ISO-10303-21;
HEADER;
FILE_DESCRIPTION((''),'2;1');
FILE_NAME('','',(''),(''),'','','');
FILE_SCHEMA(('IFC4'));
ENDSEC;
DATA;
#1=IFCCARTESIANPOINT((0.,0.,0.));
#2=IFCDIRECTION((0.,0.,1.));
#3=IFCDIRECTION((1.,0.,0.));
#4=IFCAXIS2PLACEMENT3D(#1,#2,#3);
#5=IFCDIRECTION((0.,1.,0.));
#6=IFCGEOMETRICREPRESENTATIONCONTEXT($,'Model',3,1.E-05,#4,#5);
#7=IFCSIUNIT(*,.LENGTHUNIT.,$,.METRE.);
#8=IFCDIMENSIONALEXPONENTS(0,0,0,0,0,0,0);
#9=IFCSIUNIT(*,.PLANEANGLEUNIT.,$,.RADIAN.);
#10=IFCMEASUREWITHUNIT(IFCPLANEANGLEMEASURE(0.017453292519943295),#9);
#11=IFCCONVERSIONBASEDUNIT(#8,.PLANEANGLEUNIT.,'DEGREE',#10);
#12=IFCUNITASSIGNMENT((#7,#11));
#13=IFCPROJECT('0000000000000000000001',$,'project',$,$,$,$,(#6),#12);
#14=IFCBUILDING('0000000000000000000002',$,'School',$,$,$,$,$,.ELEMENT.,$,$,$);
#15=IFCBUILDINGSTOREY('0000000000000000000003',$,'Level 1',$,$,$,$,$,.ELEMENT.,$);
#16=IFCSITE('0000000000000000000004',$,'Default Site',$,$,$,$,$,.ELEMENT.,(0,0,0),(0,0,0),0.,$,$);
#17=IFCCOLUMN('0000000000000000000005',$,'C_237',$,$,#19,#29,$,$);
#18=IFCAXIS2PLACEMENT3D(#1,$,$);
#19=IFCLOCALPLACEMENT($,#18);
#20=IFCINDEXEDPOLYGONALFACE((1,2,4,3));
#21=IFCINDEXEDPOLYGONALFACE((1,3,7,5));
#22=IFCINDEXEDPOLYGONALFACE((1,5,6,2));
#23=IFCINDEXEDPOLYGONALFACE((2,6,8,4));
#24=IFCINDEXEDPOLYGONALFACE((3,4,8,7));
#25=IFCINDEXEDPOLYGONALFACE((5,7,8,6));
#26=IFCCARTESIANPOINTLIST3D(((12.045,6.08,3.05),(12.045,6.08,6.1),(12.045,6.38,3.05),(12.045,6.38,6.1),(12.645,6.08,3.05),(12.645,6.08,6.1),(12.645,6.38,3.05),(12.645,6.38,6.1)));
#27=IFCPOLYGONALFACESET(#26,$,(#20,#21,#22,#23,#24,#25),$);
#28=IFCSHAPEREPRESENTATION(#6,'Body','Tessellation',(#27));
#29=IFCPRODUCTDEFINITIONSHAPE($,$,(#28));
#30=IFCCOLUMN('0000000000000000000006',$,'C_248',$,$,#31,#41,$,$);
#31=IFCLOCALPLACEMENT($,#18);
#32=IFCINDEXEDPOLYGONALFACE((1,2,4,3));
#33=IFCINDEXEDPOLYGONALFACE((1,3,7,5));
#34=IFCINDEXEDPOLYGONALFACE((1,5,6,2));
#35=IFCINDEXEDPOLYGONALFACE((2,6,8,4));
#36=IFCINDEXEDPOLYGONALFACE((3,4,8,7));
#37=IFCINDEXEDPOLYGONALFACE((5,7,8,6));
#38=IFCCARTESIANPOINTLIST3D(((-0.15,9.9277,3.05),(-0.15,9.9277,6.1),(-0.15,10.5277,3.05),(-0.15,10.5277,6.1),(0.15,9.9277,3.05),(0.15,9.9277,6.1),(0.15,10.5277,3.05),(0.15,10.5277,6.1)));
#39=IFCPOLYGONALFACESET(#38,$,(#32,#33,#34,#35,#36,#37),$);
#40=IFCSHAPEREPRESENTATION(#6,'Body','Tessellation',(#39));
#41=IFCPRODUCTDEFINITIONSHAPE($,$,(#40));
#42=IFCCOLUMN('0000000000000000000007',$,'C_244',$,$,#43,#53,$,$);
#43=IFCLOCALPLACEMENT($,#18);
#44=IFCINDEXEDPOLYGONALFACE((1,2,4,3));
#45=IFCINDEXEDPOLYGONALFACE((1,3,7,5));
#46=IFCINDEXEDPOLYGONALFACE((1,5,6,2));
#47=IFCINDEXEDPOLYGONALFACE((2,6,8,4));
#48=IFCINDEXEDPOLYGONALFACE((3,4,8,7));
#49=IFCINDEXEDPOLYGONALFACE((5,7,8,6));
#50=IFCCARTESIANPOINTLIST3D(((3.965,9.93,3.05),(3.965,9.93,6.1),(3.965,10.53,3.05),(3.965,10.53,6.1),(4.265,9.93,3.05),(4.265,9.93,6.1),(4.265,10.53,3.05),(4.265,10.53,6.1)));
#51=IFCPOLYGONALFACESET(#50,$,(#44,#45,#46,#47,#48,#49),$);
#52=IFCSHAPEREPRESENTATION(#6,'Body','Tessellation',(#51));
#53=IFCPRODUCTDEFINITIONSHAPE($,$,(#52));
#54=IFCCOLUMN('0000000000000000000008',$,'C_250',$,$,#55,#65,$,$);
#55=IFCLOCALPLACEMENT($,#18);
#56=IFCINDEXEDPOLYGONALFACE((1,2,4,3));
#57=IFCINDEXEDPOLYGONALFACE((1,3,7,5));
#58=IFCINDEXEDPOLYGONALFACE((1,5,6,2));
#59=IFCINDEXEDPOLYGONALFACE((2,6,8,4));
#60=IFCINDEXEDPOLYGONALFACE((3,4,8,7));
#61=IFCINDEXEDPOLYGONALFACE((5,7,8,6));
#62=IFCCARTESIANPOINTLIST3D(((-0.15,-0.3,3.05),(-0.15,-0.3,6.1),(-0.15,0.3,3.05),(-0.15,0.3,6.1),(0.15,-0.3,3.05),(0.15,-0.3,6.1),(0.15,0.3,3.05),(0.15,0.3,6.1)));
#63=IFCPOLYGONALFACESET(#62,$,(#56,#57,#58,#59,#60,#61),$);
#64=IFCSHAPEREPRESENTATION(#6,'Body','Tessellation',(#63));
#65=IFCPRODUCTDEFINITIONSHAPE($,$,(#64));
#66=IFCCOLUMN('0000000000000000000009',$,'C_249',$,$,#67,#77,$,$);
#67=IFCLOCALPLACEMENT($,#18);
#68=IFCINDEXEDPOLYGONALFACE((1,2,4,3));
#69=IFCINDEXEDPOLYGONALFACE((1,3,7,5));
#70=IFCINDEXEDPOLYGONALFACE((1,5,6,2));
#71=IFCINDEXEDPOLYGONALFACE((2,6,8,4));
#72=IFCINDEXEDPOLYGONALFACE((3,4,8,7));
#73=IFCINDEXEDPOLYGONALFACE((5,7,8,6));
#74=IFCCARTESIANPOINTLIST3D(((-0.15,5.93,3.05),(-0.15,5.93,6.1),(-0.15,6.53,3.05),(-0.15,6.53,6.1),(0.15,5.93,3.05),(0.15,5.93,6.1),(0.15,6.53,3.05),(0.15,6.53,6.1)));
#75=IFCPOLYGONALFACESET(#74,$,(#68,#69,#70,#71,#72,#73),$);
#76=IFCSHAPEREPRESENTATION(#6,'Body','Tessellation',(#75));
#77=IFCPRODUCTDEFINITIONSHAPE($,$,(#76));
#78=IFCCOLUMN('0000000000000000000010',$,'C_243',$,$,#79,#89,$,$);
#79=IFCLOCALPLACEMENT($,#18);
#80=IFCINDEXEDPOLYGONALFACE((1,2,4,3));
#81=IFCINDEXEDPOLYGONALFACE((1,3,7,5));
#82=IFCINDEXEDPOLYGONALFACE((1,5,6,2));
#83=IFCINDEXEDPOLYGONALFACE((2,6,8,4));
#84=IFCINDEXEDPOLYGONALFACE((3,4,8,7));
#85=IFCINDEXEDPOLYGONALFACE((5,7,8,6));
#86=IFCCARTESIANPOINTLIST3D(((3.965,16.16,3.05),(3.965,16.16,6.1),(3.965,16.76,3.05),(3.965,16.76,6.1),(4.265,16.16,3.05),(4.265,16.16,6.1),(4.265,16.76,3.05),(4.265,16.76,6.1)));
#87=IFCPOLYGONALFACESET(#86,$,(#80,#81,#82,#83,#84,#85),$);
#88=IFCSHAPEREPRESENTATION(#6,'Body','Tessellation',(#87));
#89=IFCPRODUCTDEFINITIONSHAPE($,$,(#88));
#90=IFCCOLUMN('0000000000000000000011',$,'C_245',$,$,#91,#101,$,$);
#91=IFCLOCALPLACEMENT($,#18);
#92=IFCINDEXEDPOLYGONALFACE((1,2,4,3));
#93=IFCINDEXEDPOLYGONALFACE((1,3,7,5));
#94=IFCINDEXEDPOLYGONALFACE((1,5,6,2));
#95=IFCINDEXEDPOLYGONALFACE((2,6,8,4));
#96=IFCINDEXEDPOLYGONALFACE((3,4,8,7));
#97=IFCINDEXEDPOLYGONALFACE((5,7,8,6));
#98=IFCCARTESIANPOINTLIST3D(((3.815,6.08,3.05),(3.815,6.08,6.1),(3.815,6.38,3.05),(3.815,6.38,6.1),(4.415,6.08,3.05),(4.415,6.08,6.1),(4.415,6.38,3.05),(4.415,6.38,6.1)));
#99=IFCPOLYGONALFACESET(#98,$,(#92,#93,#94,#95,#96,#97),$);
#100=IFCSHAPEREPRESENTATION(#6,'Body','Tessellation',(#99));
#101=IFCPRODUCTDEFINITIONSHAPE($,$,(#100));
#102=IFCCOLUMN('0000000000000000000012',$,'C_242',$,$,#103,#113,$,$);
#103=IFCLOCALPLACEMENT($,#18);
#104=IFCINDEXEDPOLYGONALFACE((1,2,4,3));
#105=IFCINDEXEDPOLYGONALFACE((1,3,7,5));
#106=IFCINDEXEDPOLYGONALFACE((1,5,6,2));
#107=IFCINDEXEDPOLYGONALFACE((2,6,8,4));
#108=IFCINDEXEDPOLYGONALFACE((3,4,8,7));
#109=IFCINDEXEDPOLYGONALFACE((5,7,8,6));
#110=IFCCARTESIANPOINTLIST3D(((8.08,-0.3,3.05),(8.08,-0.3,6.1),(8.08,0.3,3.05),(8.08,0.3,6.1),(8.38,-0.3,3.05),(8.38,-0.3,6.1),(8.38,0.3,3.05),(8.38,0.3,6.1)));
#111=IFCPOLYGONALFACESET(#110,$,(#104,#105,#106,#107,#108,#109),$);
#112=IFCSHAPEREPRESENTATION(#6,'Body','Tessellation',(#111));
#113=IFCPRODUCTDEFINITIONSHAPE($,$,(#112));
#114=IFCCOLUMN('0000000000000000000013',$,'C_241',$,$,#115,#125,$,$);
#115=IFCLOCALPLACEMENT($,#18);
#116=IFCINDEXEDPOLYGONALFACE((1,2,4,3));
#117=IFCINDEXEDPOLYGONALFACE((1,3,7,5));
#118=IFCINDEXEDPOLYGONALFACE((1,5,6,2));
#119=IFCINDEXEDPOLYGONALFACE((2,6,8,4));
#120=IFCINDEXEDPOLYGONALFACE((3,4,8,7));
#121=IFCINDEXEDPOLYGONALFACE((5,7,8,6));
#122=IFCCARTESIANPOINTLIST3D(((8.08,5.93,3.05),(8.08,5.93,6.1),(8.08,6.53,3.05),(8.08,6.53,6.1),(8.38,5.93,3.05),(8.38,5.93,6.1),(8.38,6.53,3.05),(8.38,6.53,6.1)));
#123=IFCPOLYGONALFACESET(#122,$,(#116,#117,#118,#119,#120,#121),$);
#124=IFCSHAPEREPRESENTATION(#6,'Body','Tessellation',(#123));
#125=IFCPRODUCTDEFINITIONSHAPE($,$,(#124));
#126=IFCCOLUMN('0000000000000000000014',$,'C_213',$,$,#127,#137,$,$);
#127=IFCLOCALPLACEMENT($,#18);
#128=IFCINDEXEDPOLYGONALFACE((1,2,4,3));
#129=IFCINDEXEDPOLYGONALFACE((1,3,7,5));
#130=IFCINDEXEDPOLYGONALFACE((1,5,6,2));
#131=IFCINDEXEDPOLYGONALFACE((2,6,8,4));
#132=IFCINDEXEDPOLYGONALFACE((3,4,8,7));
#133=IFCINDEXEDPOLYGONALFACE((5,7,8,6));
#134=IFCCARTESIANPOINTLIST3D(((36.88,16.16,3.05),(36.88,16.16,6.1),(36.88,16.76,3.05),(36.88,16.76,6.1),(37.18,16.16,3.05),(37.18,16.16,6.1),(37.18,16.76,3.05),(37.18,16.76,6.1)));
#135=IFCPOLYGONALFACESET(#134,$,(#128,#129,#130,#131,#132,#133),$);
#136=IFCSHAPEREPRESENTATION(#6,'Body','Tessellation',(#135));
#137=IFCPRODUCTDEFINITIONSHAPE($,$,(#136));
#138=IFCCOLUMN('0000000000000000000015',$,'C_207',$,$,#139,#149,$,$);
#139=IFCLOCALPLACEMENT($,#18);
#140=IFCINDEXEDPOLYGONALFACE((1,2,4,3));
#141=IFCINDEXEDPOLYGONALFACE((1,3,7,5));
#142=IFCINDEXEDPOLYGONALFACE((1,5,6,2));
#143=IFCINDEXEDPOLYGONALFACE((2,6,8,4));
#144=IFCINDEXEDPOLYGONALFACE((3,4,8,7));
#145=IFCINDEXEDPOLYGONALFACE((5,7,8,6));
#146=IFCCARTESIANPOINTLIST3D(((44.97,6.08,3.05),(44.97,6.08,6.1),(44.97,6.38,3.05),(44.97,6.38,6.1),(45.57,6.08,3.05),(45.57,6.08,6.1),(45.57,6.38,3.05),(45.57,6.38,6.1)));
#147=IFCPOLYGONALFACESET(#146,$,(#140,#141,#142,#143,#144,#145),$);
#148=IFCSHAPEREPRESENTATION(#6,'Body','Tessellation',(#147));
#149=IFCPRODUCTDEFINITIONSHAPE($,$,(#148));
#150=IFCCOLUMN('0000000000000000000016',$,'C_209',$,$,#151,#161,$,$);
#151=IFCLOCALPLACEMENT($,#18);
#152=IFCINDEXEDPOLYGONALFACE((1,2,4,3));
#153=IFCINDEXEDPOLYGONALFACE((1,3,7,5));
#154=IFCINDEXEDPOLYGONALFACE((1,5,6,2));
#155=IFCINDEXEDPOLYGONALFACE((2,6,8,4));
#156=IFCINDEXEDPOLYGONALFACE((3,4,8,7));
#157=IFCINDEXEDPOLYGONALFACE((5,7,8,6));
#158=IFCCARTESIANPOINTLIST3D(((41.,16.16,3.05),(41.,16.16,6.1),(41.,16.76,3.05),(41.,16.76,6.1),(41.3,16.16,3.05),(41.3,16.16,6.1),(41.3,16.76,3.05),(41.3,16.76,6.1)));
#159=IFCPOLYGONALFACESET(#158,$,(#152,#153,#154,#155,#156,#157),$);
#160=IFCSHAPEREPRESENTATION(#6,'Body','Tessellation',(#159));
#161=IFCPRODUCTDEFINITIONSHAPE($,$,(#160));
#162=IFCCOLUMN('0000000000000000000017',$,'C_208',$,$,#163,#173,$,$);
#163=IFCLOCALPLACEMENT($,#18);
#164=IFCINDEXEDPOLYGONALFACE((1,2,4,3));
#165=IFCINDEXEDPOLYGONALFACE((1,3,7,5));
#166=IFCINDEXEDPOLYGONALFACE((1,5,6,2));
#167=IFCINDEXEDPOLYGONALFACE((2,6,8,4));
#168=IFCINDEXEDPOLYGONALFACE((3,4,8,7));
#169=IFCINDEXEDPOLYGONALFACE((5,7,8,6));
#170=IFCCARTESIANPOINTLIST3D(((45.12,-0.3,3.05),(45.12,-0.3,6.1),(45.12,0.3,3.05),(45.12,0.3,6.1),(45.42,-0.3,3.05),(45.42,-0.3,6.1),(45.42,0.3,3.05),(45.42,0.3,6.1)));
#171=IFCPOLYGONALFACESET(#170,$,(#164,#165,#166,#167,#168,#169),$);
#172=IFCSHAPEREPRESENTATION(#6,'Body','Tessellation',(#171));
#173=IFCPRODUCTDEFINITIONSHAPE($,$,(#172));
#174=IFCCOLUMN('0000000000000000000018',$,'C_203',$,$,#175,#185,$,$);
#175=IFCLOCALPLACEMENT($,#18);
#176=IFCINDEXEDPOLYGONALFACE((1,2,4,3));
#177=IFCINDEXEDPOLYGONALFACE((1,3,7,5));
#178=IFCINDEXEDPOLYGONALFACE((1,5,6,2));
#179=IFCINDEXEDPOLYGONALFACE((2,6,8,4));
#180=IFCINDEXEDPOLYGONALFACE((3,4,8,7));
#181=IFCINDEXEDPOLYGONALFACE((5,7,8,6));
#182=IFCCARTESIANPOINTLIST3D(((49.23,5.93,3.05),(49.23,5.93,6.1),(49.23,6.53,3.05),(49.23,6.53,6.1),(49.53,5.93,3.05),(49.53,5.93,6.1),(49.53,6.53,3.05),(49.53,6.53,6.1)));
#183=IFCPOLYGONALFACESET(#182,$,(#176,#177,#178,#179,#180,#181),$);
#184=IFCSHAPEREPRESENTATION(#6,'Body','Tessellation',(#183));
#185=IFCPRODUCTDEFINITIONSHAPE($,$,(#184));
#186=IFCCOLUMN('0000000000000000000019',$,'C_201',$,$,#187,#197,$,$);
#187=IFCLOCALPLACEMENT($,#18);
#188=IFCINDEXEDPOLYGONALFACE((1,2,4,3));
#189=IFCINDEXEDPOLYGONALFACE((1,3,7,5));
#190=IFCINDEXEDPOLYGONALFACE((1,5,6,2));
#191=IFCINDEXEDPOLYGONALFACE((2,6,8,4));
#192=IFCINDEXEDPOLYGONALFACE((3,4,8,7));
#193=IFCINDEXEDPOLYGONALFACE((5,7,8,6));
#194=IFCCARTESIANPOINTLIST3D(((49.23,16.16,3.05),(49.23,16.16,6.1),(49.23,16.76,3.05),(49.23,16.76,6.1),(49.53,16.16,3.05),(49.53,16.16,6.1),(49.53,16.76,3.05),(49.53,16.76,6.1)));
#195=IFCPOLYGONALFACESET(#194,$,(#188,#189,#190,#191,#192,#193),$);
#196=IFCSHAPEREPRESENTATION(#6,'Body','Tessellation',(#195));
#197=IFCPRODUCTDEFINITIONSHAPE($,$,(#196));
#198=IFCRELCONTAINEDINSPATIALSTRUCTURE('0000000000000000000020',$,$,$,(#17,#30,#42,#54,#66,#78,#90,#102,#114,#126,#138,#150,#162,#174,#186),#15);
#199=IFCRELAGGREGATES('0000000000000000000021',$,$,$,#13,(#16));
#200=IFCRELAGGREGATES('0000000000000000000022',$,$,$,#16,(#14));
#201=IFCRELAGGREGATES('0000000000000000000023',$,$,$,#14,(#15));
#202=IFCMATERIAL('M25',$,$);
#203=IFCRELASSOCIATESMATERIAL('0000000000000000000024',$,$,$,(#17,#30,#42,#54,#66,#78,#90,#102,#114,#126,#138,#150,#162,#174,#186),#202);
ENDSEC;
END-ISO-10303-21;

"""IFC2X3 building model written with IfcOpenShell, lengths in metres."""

from ifc_helpers import new_model, entity, si_unit, converted_unit, direction, frame, frame_2d, origin_with_axes, place, context, project, spatial, rectangle, extrude, material, element, save


model = new_model("IFC2X3")

# Units and contexts
model_context = context("Model", 3, precision=1e-05, world=origin_with_axes(), true_north=direction((0.0, 1.0, 0.0)))
ifc_project = project(units=[si_unit("LENGTHUNIT", "METRE"), converted_unit("PLANEANGLEUNIT", "DEGREE", entity("IfcPlaneAngleMeasure", 0.017453292519943295), si_unit("PLANEANGLEUNIT", "RADIAN"), dimensions=[0, 0, 0, 0, 0, 0, 0])], contexts=[model_context])

# Site, building, storey
site = spatial("IfcSite", under=ifc_project, Name="Default Site", CompositionType="ELEMENT", RefLatitude=(0, 0, 0), RefLongitude=(0, 0, 0), RefElevation=0.0)
building = spatial("IfcBuilding", under=site, Name="School", CompositionType="ELEMENT")
storey = spatial("IfcBuildingStorey", under=building, Name="Level 1", CompositionType="ELEMENT")

# Columns
ifc_material = material(Name="M25")
placement = place(None, origin_with_axes())
element("IfcColumn", 1, at=placement, inside=storey, material=ifc_material, Name="C_237", context=model_context, shape_type="SweptSolid", body=[
    extrude(rectangle(XDim=0.6, YDim=0.3, at=frame_2d((0.0, 0.0), x_axis=(1.0, 0.0, 0.0))), frame((12.345, 6.23, 3.05), z_axis=(0.0, 0.0, 1.0), x_axis=(1.0, 0.0, 0.0)), (0.0, 0.0, 1.0), 3.05),
])
element("IfcColumn", 2, at=placement, inside=storey, material=ifc_material, Name="C_248", context=model_context, shape_type="SweptSolid", body=[
    extrude(rectangle(XDim=0.3, YDim=0.6, at=frame_2d((0.0, 0.0), x_axis=(1.0, 0.0, 0.0))), frame((0.0, 10.2277, 3.05), z_axis=(0.0, 0.0, 1.0), x_axis=(1.0, 0.0, 0.0)), (0.0, 0.0, 1.0), 3.05),
])
element("IfcColumn", 3, at=placement, inside=storey, material=ifc_material, Name="C_244", context=model_context, shape_type="SweptSolid", body=[
    extrude(rectangle(XDim=0.3, YDim=0.6, at=frame_2d((0.0, 0.0), x_axis=(1.0, 0.0, 0.0))), frame((4.115, 10.23, 3.05), z_axis=(0.0, 0.0, 1.0), x_axis=(1.0, 0.0, 0.0)), (0.0, 0.0, 1.0), 3.05),
])
element("IfcColumn", 4, at=placement, inside=storey, material=ifc_material, Name="C_250", context=model_context, shape_type="SweptSolid", body=[
    extrude(rectangle(XDim=0.3, YDim=0.6, at=frame_2d((0.0, 0.0), x_axis=(1.0, 0.0, 0.0))), frame((0.0, 0.0, 3.05), z_axis=(0.0, 0.0, 1.0), x_axis=(1.0, 0.0, 0.0)), (0.0, 0.0, 1.0), 3.05),
])
element("IfcColumn", 5, at=placement, inside=storey, material=ifc_material, Name="C_249", context=model_context, shape_type="SweptSolid", body=[
    extrude(rectangle(XDim=0.3, YDim=0.6, at=frame_2d((0.0, 0.0), x_axis=(1.0, 0.0, 0.0))), frame((0.0, 6.23, 3.05), z_axis=(0.0, 0.0, 1.0), x_axis=(1.0, 0.0, 0.0)), (0.0, 0.0, 1.0), 3.05),
])
element("IfcColumn", 6, at=placement, inside=storey, material=ifc_material, Name="C_243", context=model_context, shape_type="SweptSolid", body=[
    extrude(rectangle(XDim=0.3, YDim=0.6, at=frame_2d((0.0, 0.0), x_axis=(1.0, 0.0, 0.0))), frame((4.115, 16.46, 3.05), z_axis=(0.0, 0.0, 1.0), x_axis=(1.0, 0.0, 0.0)), (0.0, 0.0, 1.0), 3.05),
])
element("IfcColumn", 7, at=placement, inside=storey, material=ifc_material, Name="C_245", context=model_context, shape_type="SweptSolid", body=[
    extrude(rectangle(XDim=0.6, YDim=0.3, at=frame_2d((0.0, 0.0), x_axis=(1.0, 0.0, 0.0))), frame((4.115, 6.23, 3.05), z_axis=(0.0, 0.0, 1.0), x_axis=(1.0, 0.0, 0.0)), (0.0, 0.0, 1.0), 3.05),
])
element("IfcColumn", 8, at=placement, inside=storey, material=ifc_material, Name="C_242", context=model_context, shape_type="SweptSolid", body=[
    extrude(rectangle(XDim=0.3, YDim=0.6, at=frame_2d((0.0, 0.0), x_axis=(1.0, 0.0, 0.0))), frame((8.23, 0.0, 3.05), z_axis=(0.0, 0.0, 1.0), x_axis=(1.0, 0.0, 0.0)), (0.0, 0.0, 1.0), 3.05),
])
element("IfcColumn", 9, at=placement, inside=storey, material=ifc_material, Name="C_241", context=model_context, shape_type="SweptSolid", body=[
    extrude(rectangle(XDim=0.3, YDim=0.6, at=frame_2d((0.0, 0.0), x_axis=(1.0, 0.0, 0.0))), frame((8.23, 6.23, 3.05), z_axis=(0.0, 0.0, 1.0), x_axis=(1.0, 0.0, 0.0)), (0.0, 0.0, 1.0), 3.05),
])
element("IfcColumn", 10, at=placement, inside=storey, material=ifc_material, Name="C_213", context=model_context, shape_type="SweptSolid", body=[
    extrude(rectangle(XDim=0.3, YDim=0.6, at=frame_2d((0.0, 0.0), x_axis=(1.0, 0.0, 0.0))), frame((37.03, 16.46, 3.05), z_axis=(0.0, 0.0, 1.0), x_axis=(1.0, 0.0, 0.0)), (0.0, 0.0, 1.0), 3.05),
])
element("IfcColumn", 11, at=placement, inside=storey, material=ifc_material, Name="C_207", context=model_context, shape_type="SweptSolid", body=[
    extrude(rectangle(XDim=0.6, YDim=0.3, at=frame_2d((0.0, 0.0), x_axis=(1.0, 0.0, 0.0))), frame((45.27, 6.23, 3.05), z_axis=(0.0, 0.0, 1.0), x_axis=(1.0, 0.0, 0.0)), (0.0, 0.0, 1.0), 3.05),
])
element("IfcColumn", 12, at=placement, inside=storey, material=ifc_material, Name="C_209", context=model_context, shape_type="SweptSolid", body=[
    extrude(rectangle(XDim=0.3, YDim=0.6, at=frame_2d((0.0, 0.0), x_axis=(1.0, 0.0, 0.0))), frame((41.15, 16.46, 3.05), z_axis=(0.0, 0.0, 1.0), x_axis=(1.0, 0.0, 0.0)), (0.0, 0.0, 1.0), 3.05),
])
element("IfcColumn", 13, at=placement, inside=storey, material=ifc_material, Name="C_208", context=model_context, shape_type="SweptSolid", body=[
    extrude(rectangle(XDim=0.3, YDim=0.6, at=frame_2d((0.0, 0.0), x_axis=(1.0, 0.0, 0.0))), frame((45.27, 0.0, 3.05), z_axis=(0.0, 0.0, 1.0), x_axis=(1.0, 0.0, 0.0)), (0.0, 0.0, 1.0), 3.05),
])
element("IfcColumn", 14, at=placement, inside=storey, material=ifc_material, Name="C_203", context=model_context, shape_type="SweptSolid", body=[
    extrude(rectangle(XDim=0.3, YDim=0.6, at=frame_2d((0.0, 0.0), x_axis=(1.0, 0.0, 0.0))), frame((49.38, 6.23, 3.05), z_axis=(0.0, 0.0, 1.0), x_axis=(1.0, 0.0, 0.0)), (0.0, 0.0, 1.0), 3.05),
])
element("IfcColumn", 15, at=placement, inside=storey, material=ifc_material, Name="C_201", context=model_context, shape_type="SweptSolid", body=[
    extrude(rectangle(XDim=0.3, YDim=0.6, at=frame_2d((0.0, 0.0), x_axis=(1.0, 0.0, 0.0))), frame((49.38, 16.46, 3.05), z_axis=(0.0, 0.0, 1.0), x_axis=(1.0, 0.0, 0.0)), (0.0, 0.0, 1.0), 3.05),
])

save(model, "model.ifc")
